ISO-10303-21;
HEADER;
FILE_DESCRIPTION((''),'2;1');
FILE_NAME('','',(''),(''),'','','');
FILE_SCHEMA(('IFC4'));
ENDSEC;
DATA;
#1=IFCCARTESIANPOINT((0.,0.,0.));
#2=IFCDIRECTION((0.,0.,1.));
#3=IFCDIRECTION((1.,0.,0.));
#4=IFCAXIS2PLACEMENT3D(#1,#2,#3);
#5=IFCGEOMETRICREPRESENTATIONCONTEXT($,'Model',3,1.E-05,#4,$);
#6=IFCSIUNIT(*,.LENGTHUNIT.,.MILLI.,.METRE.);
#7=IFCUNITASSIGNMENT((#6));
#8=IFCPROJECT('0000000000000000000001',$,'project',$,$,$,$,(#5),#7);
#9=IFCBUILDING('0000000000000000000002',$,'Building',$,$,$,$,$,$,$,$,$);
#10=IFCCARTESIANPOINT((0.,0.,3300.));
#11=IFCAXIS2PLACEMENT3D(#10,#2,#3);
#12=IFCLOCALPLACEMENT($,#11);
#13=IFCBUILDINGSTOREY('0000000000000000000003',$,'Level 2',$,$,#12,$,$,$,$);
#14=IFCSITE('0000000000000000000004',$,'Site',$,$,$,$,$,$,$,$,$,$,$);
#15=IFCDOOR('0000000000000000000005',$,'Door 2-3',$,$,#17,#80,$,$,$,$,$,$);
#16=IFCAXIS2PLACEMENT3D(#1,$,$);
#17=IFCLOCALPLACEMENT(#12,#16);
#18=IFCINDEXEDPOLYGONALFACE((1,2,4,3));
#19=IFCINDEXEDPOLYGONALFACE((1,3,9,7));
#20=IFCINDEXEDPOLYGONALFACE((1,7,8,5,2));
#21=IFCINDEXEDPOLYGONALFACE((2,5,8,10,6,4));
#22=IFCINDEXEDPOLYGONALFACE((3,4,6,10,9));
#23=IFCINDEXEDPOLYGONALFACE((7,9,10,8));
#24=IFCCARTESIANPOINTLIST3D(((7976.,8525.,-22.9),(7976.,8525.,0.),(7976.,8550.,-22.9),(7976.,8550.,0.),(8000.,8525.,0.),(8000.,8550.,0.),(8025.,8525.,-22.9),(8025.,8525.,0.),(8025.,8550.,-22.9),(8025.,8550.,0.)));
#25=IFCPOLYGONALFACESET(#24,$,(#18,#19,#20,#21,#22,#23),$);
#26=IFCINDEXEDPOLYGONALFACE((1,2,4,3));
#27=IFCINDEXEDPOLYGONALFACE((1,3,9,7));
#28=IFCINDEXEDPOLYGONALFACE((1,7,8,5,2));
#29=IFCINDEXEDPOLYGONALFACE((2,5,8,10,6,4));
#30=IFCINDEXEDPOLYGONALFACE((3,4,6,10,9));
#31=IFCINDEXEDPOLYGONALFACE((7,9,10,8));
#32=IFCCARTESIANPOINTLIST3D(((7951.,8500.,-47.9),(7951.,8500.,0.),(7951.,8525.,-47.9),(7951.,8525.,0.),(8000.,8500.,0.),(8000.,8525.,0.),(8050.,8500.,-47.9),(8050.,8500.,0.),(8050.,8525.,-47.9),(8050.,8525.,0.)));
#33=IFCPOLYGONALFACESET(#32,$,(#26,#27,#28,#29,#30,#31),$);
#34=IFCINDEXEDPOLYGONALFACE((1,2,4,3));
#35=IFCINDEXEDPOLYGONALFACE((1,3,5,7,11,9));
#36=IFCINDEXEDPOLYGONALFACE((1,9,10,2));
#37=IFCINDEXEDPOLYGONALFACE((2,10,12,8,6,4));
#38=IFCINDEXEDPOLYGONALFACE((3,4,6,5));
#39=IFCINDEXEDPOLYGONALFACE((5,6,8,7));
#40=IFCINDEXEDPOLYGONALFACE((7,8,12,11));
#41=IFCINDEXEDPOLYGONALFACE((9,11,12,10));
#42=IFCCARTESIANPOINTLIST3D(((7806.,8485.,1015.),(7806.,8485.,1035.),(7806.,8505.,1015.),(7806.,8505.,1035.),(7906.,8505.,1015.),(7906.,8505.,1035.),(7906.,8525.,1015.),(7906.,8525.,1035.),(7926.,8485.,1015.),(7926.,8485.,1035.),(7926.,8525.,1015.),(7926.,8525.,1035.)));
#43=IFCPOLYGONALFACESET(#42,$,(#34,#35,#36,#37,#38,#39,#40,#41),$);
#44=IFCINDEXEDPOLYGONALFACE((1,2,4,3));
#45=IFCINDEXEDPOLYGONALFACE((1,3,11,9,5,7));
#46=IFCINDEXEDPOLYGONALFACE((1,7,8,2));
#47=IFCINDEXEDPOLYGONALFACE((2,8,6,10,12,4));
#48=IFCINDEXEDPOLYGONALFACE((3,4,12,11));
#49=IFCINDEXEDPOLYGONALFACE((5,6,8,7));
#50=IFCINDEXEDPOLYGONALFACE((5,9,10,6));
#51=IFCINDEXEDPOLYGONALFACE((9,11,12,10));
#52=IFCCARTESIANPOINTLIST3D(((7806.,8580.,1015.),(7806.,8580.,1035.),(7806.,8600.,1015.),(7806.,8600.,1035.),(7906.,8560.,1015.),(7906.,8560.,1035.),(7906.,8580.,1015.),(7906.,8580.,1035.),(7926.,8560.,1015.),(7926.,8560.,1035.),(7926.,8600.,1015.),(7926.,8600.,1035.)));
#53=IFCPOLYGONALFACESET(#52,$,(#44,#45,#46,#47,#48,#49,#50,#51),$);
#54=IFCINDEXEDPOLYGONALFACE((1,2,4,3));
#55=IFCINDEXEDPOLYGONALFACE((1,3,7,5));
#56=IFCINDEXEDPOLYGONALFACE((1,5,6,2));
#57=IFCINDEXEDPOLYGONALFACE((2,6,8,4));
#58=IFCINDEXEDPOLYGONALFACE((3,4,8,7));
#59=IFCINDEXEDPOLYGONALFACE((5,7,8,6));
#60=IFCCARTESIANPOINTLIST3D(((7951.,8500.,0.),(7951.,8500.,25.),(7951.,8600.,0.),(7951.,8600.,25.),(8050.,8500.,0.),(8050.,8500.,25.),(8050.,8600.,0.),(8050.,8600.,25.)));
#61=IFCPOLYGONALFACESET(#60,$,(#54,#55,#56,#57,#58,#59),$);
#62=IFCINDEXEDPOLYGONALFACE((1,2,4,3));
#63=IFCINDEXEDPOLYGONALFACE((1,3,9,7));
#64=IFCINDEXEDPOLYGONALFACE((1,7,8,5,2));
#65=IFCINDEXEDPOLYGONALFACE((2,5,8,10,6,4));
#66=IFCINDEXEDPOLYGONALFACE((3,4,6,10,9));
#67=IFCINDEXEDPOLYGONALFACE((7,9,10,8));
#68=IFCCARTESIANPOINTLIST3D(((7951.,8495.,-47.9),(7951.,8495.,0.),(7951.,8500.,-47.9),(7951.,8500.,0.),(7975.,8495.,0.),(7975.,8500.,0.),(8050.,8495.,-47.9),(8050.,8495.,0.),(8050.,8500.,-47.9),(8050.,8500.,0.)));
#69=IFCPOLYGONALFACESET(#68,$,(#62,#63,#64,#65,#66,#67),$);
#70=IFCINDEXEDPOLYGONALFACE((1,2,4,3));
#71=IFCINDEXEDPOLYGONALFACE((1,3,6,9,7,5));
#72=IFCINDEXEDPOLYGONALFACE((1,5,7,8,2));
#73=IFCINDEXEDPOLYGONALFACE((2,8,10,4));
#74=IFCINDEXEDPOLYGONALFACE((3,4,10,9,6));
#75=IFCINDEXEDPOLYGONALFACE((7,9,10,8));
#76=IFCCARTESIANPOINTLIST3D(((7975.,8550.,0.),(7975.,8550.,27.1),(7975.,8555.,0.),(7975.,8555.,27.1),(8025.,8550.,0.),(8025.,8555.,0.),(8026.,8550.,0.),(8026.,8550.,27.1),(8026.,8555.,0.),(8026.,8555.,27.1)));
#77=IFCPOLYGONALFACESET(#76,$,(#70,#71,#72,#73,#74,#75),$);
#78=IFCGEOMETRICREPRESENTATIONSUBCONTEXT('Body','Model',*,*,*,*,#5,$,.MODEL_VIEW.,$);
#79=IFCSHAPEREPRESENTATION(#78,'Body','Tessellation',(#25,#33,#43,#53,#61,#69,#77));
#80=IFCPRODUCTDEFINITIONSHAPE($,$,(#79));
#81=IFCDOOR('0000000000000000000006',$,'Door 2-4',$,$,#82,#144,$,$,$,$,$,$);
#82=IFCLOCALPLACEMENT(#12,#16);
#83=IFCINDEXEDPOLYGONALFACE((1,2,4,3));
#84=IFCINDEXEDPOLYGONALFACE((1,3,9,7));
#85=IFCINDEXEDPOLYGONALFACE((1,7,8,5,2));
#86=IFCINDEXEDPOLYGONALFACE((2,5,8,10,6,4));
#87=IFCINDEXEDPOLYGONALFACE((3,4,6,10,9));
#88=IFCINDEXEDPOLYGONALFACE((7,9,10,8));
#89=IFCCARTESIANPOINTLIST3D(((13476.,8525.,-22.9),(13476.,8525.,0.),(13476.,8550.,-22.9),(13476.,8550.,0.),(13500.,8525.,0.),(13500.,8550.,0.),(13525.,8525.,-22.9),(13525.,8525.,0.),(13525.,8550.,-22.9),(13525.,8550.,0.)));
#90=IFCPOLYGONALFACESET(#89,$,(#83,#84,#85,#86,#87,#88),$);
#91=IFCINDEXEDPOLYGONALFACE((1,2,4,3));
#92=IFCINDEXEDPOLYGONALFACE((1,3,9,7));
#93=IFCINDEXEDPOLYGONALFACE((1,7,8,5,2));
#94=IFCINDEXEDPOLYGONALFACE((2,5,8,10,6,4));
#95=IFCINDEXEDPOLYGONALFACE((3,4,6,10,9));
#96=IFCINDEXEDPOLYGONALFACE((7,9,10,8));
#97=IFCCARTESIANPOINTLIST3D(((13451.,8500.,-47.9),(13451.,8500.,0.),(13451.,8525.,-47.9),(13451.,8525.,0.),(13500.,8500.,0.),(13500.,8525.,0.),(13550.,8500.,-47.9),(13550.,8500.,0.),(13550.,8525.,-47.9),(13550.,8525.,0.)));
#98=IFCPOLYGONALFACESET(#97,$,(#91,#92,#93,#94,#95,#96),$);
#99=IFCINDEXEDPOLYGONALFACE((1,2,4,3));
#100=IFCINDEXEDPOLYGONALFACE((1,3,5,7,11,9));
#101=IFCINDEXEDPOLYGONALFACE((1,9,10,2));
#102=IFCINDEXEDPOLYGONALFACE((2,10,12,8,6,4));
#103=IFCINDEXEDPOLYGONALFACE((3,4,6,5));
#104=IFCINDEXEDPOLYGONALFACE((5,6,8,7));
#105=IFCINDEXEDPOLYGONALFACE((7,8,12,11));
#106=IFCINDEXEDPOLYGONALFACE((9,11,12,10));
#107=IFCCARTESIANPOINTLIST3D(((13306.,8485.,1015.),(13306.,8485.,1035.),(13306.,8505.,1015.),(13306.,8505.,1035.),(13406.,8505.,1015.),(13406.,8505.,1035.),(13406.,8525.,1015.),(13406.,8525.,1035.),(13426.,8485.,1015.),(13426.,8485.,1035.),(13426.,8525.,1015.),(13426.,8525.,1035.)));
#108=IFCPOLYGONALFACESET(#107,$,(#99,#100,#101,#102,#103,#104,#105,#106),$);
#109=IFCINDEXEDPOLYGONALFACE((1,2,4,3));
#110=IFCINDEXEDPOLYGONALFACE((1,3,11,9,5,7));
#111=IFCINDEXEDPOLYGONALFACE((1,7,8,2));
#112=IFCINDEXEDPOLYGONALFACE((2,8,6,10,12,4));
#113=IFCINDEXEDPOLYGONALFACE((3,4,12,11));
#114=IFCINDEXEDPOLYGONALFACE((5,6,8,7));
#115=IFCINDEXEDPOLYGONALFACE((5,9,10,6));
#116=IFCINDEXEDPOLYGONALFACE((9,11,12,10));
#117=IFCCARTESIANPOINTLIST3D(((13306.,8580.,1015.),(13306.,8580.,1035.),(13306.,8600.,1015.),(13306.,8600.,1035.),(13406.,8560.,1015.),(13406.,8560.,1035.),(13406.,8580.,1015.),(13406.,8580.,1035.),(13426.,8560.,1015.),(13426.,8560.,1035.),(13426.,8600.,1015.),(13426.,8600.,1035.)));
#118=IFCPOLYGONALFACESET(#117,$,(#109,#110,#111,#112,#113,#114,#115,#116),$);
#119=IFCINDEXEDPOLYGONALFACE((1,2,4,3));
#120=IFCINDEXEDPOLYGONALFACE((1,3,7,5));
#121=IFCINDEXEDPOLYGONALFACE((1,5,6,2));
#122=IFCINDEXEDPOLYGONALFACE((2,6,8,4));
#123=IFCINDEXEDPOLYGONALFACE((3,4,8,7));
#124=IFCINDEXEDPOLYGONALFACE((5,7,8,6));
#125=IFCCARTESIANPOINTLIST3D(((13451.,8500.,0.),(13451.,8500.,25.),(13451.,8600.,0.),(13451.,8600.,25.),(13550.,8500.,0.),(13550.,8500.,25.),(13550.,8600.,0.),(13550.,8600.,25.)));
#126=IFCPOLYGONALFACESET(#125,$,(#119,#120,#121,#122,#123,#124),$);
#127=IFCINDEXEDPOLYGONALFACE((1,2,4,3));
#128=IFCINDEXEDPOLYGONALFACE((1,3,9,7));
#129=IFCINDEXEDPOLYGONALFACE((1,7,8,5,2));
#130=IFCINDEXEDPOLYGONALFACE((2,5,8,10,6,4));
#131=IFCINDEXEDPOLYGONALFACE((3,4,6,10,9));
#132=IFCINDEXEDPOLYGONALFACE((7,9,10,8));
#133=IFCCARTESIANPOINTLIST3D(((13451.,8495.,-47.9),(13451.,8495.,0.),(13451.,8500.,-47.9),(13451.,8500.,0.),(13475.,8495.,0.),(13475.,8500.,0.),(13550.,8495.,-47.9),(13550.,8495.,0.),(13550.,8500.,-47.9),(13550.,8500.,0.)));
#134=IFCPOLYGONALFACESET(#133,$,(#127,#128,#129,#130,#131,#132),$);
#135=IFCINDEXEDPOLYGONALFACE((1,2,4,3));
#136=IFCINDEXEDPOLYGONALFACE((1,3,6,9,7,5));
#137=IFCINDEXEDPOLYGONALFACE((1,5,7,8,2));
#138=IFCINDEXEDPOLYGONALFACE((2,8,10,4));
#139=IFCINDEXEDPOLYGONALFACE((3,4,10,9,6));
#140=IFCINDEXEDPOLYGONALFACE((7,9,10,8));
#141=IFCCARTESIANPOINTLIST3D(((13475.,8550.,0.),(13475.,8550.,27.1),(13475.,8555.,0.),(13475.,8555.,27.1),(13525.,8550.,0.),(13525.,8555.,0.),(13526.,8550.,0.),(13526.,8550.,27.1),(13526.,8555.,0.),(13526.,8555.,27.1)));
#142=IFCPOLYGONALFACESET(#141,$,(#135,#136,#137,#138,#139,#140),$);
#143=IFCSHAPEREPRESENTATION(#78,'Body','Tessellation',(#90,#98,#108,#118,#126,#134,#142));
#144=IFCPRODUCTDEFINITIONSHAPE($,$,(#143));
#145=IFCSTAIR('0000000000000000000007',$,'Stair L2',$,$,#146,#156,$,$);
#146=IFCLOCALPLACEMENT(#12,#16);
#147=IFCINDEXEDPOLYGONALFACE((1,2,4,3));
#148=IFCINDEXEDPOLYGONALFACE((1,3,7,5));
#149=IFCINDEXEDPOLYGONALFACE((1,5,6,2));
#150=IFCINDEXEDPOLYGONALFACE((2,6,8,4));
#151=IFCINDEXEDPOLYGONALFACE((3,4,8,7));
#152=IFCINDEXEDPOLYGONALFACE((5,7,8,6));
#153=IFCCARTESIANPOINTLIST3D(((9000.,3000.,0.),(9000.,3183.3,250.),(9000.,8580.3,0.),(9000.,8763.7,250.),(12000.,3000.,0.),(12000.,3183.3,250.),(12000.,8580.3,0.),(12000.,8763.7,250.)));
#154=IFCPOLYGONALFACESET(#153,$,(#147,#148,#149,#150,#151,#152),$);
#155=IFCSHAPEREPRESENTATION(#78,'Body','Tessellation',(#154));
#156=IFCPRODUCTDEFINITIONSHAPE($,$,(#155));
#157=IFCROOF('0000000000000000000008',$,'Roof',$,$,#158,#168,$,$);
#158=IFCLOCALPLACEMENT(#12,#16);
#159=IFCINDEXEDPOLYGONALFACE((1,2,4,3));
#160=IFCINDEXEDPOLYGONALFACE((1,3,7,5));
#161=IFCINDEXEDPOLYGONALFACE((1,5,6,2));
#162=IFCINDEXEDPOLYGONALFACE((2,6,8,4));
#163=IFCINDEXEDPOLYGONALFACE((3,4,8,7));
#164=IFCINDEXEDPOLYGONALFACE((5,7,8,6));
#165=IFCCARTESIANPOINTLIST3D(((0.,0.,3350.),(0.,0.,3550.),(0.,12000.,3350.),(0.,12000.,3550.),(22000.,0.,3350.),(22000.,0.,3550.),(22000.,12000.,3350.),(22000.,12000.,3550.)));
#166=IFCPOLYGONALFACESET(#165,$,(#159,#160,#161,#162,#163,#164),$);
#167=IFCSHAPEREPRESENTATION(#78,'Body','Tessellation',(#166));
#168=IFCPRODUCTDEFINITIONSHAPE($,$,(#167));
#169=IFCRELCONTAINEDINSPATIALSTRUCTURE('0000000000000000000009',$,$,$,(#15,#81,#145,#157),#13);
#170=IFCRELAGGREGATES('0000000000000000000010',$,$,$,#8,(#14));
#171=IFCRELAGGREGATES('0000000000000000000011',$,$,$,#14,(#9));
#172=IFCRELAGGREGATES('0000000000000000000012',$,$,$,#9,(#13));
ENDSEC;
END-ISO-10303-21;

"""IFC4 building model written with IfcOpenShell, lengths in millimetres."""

from ifc_helpers import new_model, si_unit, frame, origin_with_axes, place, context, subcontext, project, spatial, line, indexed_curve, outline, extrude, element, save


model = new_model("IFC4")

# Units and contexts
model_context = context("Model", 3, precision=1e-05, world=origin_with_axes())
body_context = subcontext(model_context, "Body", "Model", "MODEL_VIEW")
ifc_project = project(units=[si_unit("LENGTHUNIT", "METRE", prefix="MILLI")], contexts=[model_context])

# Site, building, storey
site = spatial("IfcSite", under=ifc_project, Name="Site")
building = spatial("IfcBuilding", under=site, Name="Building")
storey_placement = place(None, frame((0.0, 0.0, 3300.0), z_axis=(0.0, 0.0, 1.0), x_axis=(1.0, 0.0, 0.0)))
storey = spatial("IfcBuildingStorey", under=building, at=storey_placement, Name="Level 2")

# Doors
door_1_placement = place(storey_placement, frame((8000.0, 8500.0, 0.0), z_axis=(0.0, 0.0, 1.0), x_axis=(1.0, 0.0, 0.0)))
element("IfcDoor", 1, at=door_1_placement, inside=storey, Name="Door 2-3", context=body_context, shape_type="SweptSolid", body=[
    extrude(outline(indexed_curve([(0.0, 0.0), (0.0, 2.1), (1.0, 2.1), (1.0, 0.0), (-24.0, 0.0), (-24.0, -22.9), (25.0, -22.9), (25.0, 0.0)], segments=[line(1, 2, 3, 4, 5, 6, 7, 8, 1)])), frame((0.0, 25.0, 0.0), z_axis=(0.0, -1.0, 0.0), x_axis=(1.0, 0.0, 0.0)), (0.0, 0.0, -1.0), 25.0),
    extrude(outline(indexed_curve([(0.0, 0.0), (0.0, 2.1), (1.0, 2.1), (1.0, 0.0), (-49.0, 0.0), (-49.0, -47.9), (50.0, -47.9), (50.0, 0.0)], segments=[line(1, 2, 3, 4, 5, 6, 7, 8, 1)])), frame((0.0, 0.0, 0.0), z_axis=(0.0, -1.0, 0.0), x_axis=(1.0, 0.0, 0.0)), (0.0, 0.0, -1.0), 25.0),
    extrude(outline(indexed_curve([(0.0, 0.0), (-49.0, 0.0), (-49.0, 35.0), (0.0, 35.0)], segments=[line(1, 2, 3, 4, 1)])), frame((25.0, 25.0, 25.0), z_axis=(0.0, 0.0, 1.0), x_axis=(1.0, 0.0, 0.0)), (0.0, 0.0, 1.0), -47.9),
    extrude(outline(indexed_curve([(0.0, 0.0), (0.0, -40.0), (-120.0, -40.0), (-120.0, -20.0), (-20.0, -20.0), (-20.0, 0.0)], segments=[line(1, 2, 3, 4, 5, 6, 1)])), frame((-74.0, 25.0, 1015.0), z_axis=(0.0, 0.0, 1.0), x_axis=(1.0, 0.0, 0.0)), (0.0, 0.0, 1.0), 20.0),
    extrude(outline(indexed_curve([(0.0, 0.0), (0.0, 40.0), (-120.0, 40.0), (-120.0, 20.0), (-20.0, 20.0), (-20.0, 0.0)], segments=[line(1, 2, 3, 4, 5, 6, 1)])), frame((-74.0, 60.0, 1015.0), z_axis=(0.0, 0.0, 1.0), x_axis=(1.0, 0.0, 0.0)), (0.0, 0.0, 1.0), 20.0),
    extrude(outline(indexed_curve([(0.0, 0.0), (-99.0, 0.0), (-99.0, 100.0), (0.0, 100.0)], segments=[line(1, 2, 3, 4, 1)])), frame((50.0, 0.0, 0.0), z_axis=(0.0, 0.0, 1.0), x_axis=(1.0, 0.0, 0.0)), (0.0, 0.0, 1.0), 25.0),
    extrude(outline(indexed_curve([(0.0, 0.0), (0.0, 27.1), (51.0, 27.1), (51.0, 0.0), (-24.0, 0.0), (-24.0, -47.9), (75.0, -47.9), (75.0, 0.0)], segments=[line(1, 2, 3, 4, 5, 6, 7, 8, 1)])), frame((-25.0, -5.0, 0.0), z_axis=(0.0, -1.0, 0.0), x_axis=(1.0, 0.0, 0.0)), (0.0, 0.0, -1.0), 5.0),
    extrude(outline(indexed_curve([(0.0, 0.0), (0.0, 27.1), (51.0, 27.1), (51.0, 0.0), (1.0, 0.0), (1.0, -22.9), (50.0, -22.9), (50.0, 0.0)], segments=[line(1, 2, 3, 4, 5, 6, 7, 8, 1)])), frame((-25.0, 50.0, 0.0), z_axis=(0.0, -1.0, 0.0), x_axis=(1.0, 0.0, 0.0)), (0.0, 0.0, -1.0), 5.0),
])
door_2_placement = place(storey_placement, frame((13500.0, 8500.0, 0.0), z_axis=(0.0, 0.0, 1.0), x_axis=(1.0, 0.0, 0.0)))
element("IfcDoor", 2, at=door_2_placement, inside=storey, Name="Door 2-4", context=body_context, shape_type="SweptSolid", body=[
    extrude(outline(indexed_curve([(0.0, 0.0), (0.0, 2.1), (1.0, 2.1), (1.0, 0.0), (-24.0, 0.0), (-24.0, -22.9), (25.0, -22.9), (25.0, 0.0)], segments=[line(1, 2, 3, 4, 5, 6, 7, 8, 1)])), frame((0.0, 25.0, 0.0), z_axis=(0.0, -1.0, 0.0), x_axis=(1.0, 0.0, 0.0)), (0.0, 0.0, -1.0), 25.0),
    extrude(outline(indexed_curve([(0.0, 0.0), (0.0, 2.1), (1.0, 2.1), (1.0, 0.0), (-49.0, 0.0), (-49.0, -47.9), (50.0, -47.9), (50.0, 0.0)], segments=[line(1, 2, 3, 4, 5, 6, 7, 8, 1)])), frame((0.0, 0.0, 0.0), z_axis=(0.0, -1.0, 0.0), x_axis=(1.0, 0.0, 0.0)), (0.0, 0.0, -1.0), 25.0),
    extrude(outline(indexed_curve([(0.0, 0.0), (-49.0, 0.0), (-49.0, 35.0), (0.0, 35.0)], segments=[line(1, 2, 3, 4, 1)])), frame((25.0, 25.0, 25.0), z_axis=(0.0, 0.0, 1.0), x_axis=(1.0, 0.0, 0.0)), (0.0, 0.0, 1.0), -47.9),
    extrude(outline(indexed_curve([(0.0, 0.0), (0.0, -40.0), (-120.0, -40.0), (-120.0, -20.0), (-20.0, -20.0), (-20.0, 0.0)], segments=[line(1, 2, 3, 4, 5, 6, 1)])), frame((-74.0, 25.0, 1015.0), z_axis=(0.0, 0.0, 1.0), x_axis=(1.0, 0.0, 0.0)), (0.0, 0.0, 1.0), 20.0),
    extrude(outline(indexed_curve([(0.0, 0.0), (0.0, 40.0), (-120.0, 40.0), (-120.0, 20.0), (-20.0, 20.0), (-20.0, 0.0)], segments=[line(1, 2, 3, 4, 5, 6, 1)])), frame((-74.0, 60.0, 1015.0), z_axis=(0.0, 0.0, 1.0), x_axis=(1.0, 0.0, 0.0)), (0.0, 0.0, 1.0), 20.0),
    extrude(outline(indexed_curve([(0.0, 0.0), (-99.0, 0.0), (-99.0, 100.0), (0.0, 100.0)], segments=[line(1, 2, 3, 4, 1)])), frame((50.0, 0.0, 0.0), z_axis=(0.0, 0.0, 1.0), x_axis=(1.0, 0.0, 0.0)), (0.0, 0.0, 1.0), 25.0),
    extrude(outline(indexed_curve([(0.0, 0.0), (0.0, 27.1), (51.0, 27.1), (51.0, 0.0), (-24.0, 0.0), (-24.0, -47.9), (75.0, -47.9), (75.0, 0.0)], segments=[line(1, 2, 3, 4, 5, 6, 7, 8, 1)])), frame((-25.0, -5.0, 0.0), z_axis=(0.0, -1.0, 0.0), x_axis=(1.0, 0.0, 0.0)), (0.0, 0.0, -1.0), 5.0),
    extrude(outline(indexed_curve([(0.0, 0.0), (0.0, 27.1), (51.0, 27.1), (51.0, 0.0), (1.0, 0.0), (1.0, -22.9), (50.0, -22.9), (50.0, 0.0)], segments=[line(1, 2, 3, 4, 5, 6, 7, 8, 1)])), frame((-25.0, 50.0, 0.0), z_axis=(0.0, -1.0, 0.0), x_axis=(1.0, 0.0, 0.0)), (0.0, 0.0, -1.0), 5.0),
])

# Stair
stair_placement = place(storey_placement, frame((9000.0, 3000.0, 0.0), z_axis=(0.0, 0.0, 1.0), x_axis=(1.0, 0.0, 0.0)))
element("IfcStair", 3, at=stair_placement, inside=storey, Name="Stair L2", context=body_context, shape_type="SweptSolid", body=[
    extrude(outline(indexed_curve([(0.0, 0.0), (3000.0, 0.0), (3000.0, 5580.3), (0.0, 5580.3), (0.0, 0.0)])), None, (0.0, 0.591364, 0.806405), 310.0),
])

# Roof
roof_placement = place(storey_placement, frame((0.0, 0.0, 3350.0), z_axis=(0.0, 0.0, 1.0), x_axis=(1.0, 0.0, 0.0)))
element("IfcRoof", 4, at=roof_placement, inside=storey, Name="Roof", context=body_context, shape_type="SweptSolid", body=[
    extrude(outline(indexed_curve([(0.0, 0.0), (22000.0, 0.0), (22000.0, 12000.0), (0.0, 12000.0), (0.0, 0.0)])), None, (0.0, 0.0, 1.0), 200.0),
])

save(model, "model.ifc")
